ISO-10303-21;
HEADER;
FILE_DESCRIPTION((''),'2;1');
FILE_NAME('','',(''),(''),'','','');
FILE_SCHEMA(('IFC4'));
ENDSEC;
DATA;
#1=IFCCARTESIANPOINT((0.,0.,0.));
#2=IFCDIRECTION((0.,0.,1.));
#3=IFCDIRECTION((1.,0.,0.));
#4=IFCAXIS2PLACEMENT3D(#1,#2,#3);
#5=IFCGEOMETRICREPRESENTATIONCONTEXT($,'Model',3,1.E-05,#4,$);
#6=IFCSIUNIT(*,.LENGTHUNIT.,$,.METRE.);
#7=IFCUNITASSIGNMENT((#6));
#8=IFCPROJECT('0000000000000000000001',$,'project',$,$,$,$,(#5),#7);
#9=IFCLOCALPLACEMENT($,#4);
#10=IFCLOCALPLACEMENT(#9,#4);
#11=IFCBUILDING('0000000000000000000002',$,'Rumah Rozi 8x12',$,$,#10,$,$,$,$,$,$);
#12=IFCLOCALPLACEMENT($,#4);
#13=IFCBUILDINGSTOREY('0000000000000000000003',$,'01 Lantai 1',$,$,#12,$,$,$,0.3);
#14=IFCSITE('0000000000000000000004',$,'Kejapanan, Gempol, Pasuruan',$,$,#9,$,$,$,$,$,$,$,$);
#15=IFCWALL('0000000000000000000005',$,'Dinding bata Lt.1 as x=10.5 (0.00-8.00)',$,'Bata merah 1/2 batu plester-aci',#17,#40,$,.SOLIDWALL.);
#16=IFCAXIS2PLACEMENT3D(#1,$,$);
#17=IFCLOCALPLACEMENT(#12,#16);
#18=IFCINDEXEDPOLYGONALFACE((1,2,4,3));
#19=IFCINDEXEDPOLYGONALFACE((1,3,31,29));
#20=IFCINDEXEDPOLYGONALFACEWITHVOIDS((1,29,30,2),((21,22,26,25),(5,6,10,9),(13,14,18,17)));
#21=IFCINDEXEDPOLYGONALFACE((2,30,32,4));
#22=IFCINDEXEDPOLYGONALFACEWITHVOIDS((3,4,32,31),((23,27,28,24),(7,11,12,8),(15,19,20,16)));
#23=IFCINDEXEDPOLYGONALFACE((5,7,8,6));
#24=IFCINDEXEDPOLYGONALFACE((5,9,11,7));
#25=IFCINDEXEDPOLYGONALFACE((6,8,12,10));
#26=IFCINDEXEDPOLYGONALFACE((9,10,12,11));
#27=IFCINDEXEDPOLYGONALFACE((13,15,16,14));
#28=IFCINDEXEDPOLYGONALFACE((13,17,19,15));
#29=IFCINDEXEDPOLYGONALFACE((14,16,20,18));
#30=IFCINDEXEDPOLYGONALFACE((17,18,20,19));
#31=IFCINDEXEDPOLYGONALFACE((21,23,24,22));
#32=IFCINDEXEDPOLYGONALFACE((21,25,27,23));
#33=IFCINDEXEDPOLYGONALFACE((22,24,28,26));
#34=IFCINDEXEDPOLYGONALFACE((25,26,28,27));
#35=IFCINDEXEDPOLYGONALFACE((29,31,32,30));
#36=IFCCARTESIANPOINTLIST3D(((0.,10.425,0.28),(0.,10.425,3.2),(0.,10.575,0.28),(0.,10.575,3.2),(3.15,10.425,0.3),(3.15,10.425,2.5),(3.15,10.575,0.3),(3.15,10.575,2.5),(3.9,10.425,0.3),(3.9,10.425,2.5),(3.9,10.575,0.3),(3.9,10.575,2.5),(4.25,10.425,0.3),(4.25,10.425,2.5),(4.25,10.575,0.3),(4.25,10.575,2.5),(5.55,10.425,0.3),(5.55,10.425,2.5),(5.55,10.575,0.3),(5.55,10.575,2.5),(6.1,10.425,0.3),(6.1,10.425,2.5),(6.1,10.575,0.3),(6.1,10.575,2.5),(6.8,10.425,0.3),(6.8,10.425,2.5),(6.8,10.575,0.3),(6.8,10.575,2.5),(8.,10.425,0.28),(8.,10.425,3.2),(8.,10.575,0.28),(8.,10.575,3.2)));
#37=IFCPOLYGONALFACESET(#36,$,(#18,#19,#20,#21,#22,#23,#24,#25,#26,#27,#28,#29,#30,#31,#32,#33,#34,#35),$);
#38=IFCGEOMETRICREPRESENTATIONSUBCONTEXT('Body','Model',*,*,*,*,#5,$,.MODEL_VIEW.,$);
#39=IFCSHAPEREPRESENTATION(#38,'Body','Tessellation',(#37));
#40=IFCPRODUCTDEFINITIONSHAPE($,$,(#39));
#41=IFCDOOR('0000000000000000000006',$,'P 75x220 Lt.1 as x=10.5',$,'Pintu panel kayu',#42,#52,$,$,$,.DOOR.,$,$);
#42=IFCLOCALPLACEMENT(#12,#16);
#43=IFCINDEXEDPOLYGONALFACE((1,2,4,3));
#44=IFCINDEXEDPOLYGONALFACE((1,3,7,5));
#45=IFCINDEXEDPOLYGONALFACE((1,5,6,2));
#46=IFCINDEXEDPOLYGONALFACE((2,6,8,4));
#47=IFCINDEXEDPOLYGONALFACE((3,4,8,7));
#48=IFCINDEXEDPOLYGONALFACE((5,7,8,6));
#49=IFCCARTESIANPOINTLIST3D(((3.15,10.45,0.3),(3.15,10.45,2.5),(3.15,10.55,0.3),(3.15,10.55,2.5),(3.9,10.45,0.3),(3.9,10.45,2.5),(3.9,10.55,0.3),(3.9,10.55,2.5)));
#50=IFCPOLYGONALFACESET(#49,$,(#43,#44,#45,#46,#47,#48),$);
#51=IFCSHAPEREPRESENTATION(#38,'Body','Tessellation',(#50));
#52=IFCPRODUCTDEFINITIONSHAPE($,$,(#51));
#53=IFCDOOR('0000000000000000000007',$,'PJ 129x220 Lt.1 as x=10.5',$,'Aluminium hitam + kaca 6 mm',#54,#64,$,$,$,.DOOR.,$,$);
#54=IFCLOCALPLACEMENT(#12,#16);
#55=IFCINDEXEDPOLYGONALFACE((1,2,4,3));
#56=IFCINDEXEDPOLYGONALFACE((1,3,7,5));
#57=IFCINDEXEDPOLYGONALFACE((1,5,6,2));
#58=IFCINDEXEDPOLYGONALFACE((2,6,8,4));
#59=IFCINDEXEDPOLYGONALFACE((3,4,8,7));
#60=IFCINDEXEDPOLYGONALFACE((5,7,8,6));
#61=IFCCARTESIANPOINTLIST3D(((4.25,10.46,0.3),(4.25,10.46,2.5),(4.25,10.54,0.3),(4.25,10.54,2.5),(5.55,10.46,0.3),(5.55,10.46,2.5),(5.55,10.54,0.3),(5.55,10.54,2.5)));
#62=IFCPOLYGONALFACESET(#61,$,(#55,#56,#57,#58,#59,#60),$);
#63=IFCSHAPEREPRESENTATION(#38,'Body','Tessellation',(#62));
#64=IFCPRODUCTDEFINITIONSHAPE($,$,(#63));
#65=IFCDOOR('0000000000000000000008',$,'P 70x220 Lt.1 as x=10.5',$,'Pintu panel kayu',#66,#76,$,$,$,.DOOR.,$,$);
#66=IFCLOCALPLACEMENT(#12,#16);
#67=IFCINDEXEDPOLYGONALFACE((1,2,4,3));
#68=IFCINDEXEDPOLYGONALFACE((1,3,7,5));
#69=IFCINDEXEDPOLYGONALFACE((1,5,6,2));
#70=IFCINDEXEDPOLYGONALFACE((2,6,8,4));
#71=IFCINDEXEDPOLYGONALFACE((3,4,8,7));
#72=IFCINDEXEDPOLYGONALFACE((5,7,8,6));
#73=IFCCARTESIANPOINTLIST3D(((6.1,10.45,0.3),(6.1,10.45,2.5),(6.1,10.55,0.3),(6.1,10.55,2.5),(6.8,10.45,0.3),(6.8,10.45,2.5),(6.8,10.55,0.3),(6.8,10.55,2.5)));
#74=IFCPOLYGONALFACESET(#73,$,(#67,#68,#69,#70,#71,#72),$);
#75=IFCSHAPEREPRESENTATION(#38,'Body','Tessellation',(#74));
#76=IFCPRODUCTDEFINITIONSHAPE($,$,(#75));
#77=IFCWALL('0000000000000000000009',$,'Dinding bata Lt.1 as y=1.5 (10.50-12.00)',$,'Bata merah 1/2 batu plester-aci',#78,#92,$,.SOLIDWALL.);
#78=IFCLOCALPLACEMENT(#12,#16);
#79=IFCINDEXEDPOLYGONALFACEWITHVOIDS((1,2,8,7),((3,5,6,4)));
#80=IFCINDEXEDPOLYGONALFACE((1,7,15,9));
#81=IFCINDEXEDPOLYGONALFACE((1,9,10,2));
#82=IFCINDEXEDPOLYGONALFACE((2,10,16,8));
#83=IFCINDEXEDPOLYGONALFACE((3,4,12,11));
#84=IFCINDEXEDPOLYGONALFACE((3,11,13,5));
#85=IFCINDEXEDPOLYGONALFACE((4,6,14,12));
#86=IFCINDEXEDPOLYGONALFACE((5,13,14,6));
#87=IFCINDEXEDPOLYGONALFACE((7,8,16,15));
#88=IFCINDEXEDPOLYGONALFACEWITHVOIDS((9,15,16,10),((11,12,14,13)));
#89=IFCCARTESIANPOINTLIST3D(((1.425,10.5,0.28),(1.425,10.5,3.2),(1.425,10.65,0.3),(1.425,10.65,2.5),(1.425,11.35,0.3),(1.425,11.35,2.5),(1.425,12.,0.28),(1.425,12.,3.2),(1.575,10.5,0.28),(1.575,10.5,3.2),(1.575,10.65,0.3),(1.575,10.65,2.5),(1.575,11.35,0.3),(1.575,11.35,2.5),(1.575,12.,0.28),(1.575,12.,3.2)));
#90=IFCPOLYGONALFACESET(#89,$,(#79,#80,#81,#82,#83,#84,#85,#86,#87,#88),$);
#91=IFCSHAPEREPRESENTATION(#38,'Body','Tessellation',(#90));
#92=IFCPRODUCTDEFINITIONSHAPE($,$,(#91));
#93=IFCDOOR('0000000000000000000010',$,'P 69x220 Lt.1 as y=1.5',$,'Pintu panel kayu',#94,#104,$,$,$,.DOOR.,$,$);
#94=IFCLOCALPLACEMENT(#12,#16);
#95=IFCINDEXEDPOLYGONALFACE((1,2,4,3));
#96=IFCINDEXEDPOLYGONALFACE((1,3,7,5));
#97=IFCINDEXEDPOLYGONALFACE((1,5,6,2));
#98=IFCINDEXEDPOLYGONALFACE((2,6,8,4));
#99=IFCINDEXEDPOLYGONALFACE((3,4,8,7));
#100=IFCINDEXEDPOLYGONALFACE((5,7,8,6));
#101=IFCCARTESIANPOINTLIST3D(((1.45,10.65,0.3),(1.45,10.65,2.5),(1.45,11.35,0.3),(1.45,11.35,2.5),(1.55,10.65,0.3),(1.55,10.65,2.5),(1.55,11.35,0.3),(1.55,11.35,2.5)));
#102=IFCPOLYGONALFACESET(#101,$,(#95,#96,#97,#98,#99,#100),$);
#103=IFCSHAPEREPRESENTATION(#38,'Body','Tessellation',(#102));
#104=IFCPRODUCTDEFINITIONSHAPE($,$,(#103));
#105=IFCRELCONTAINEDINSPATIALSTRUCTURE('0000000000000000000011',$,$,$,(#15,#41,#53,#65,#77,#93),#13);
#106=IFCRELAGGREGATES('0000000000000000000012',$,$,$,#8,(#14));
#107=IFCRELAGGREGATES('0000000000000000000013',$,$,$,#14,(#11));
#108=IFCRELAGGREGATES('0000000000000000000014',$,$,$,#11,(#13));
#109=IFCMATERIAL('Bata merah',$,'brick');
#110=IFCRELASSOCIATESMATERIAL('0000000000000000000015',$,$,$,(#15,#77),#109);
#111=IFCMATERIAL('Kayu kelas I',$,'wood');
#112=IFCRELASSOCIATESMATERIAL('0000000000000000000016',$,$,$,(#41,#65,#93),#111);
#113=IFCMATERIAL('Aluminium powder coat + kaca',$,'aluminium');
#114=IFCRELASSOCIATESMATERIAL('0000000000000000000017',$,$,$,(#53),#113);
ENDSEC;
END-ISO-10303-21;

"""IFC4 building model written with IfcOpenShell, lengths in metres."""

from ifc_helpers import new_model, si_unit, frame, origin_with_axes, place, context, subcontext, project, spatial, line, indexed_curve, outline, extrude, material, element, fill, save


model = new_model("IFC4")

# Units and contexts
model_context = context("Model", 3, precision=1e-05, world=origin_with_axes())
body_context = subcontext(model_context, "Body", "Model", "MODEL_VIEW")
ifc_project = project(units=[si_unit("LENGTHUNIT", "METRE")], contexts=[model_context])

# Site, building, storey
site_placement = place(None, origin_with_axes())
site = spatial("IfcSite", under=ifc_project, at=site_placement, Name="Kejapanan, Gempol, Pasuruan")
building_placement = place(site_placement, origin_with_axes())
building = spatial("IfcBuilding", under=site, at=building_placement, Name="Rumah Rozi 8x12")
storey_placement = place(None, origin_with_axes())
storey = spatial("IfcBuildingStorey", under=building, at=storey_placement, Name="01 Lantai 1", Elevation=0.3)

# Shared definitions
ifc_material_1 = material(Name="Bata merah", Category="brick")
ifc_material_2 = material(Name="Aluminium powder coat + kaca", Category="aluminium")

# Shared definitions
ifc_material_3 = material(Name="Kayu kelas I", Category="wood")

# Wall, openings, doors
wall_1_placement = place(storey_placement, origin_with_axes())
wall_1 = element("IfcWall", 1, at=wall_1_placement, inside=storey, material=ifc_material_1, Name="Dinding bata Lt.1 as x=10.5 (0.00-8.00)", ObjectType="Bata merah 1/2 batu plester-aci", PredefinedType="SOLIDWALL", context=body_context, shape_type="SweptSolid", body=[
    extrude(outline(indexed_curve([(0.0, 10.425), (8.0, 10.425), (8.0, 10.575), (0.0, 10.575)], segments=[line(1, 2, 3, 4, 1)])), frame((0.0, 0.0, 0.28), z_axis=(0.0, 0.0, 1.0), x_axis=(1.0, 0.0, 0.0)), (0.0, 0.0, 1.0), 2.92),
])
opening_1_placement = place(wall_1_placement, origin_with_axes())
opening_1 = element("IfcOpeningElement", 2, at=opening_1_placement, cuts=wall_1, context=body_context, shape_type="SweptSolid", body=[
    extrude(outline(indexed_curve([(3.15, 10.415), (3.9, 10.415), (3.9, 10.585), (3.15, 10.585)], segments=[line(1, 2, 3, 4, 1)])), frame((0.0, 0.0, 0.3), z_axis=(0.0, 0.0, 1.0), x_axis=(1.0, 0.0, 0.0)), (0.0, 0.0, 1.0), 2.2),
])
opening_2_placement = place(wall_1_placement, origin_with_axes())
opening_2 = element("IfcOpeningElement", 3, at=opening_2_placement, cuts=wall_1, context=body_context, shape_type="SweptSolid", body=[
    extrude(outline(indexed_curve([(4.25, 10.415), (5.55, 10.415), (5.55, 10.585), (4.25, 10.585)], segments=[line(1, 2, 3, 4, 1)])), frame((0.0, 0.0, 0.3), z_axis=(0.0, 0.0, 1.0), x_axis=(1.0, 0.0, 0.0)), (0.0, 0.0, 1.0), 2.2),
])
opening_3_placement = place(wall_1_placement, origin_with_axes())
opening_3 = element("IfcOpeningElement", 4, at=opening_3_placement, cuts=wall_1, context=body_context, shape_type="SweptSolid", body=[
    extrude(outline(indexed_curve([(6.1, 10.415), (6.8, 10.415), (6.8, 10.585), (6.1, 10.585)], segments=[line(1, 2, 3, 4, 1)])), frame((0.0, 0.0, 0.3), z_axis=(0.0, 0.0, 1.0), x_axis=(1.0, 0.0, 0.0)), (0.0, 0.0, 1.0), 2.2),
])
door_1_placement = place(storey_placement, origin_with_axes())
door_1 = element("IfcDoor", 5, at=door_1_placement, inside=storey, material=ifc_material_3, Name="P 75x220 Lt.1 as x=10.5", ObjectType="Pintu panel kayu", PredefinedType="DOOR", context=body_context, shape_type="SweptSolid", body=[
    extrude(outline(indexed_curve([(3.15, 10.45), (3.9, 10.45), (3.9, 10.55), (3.15, 10.55)], segments=[line(1, 2, 3, 4, 1)])), frame((0.0, 0.0, 0.3), z_axis=(0.0, 0.0, 1.0), x_axis=(1.0, 0.0, 0.0)), (0.0, 0.0, 1.0), 2.2),
])
fill(opening_1, door_1)
door_2_placement = place(storey_placement, origin_with_axes())
door_2 = element("IfcDoor", 6, at=door_2_placement, inside=storey, material=ifc_material_2, Name="PJ 129x220 Lt.1 as x=10.5", ObjectType="Aluminium hitam + kaca 6 mm", PredefinedType="DOOR", context=body_context, shape_type="SweptSolid", body=[
    extrude(outline(indexed_curve([(4.25, 10.46), (5.55, 10.46), (5.55, 10.54), (4.25, 10.54)], segments=[line(1, 2, 3, 4, 1)])), frame((0.0, 0.0, 0.3), z_axis=(0.0, 0.0, 1.0), x_axis=(1.0, 0.0, 0.0)), (0.0, 0.0, 1.0), 2.2),
])
fill(opening_2, door_2)
door_3_placement = place(storey_placement, origin_with_axes())
door_3 = element("IfcDoor", 7, at=door_3_placement, inside=storey, material=ifc_material_3, Name="P 70x220 Lt.1 as x=10.5", ObjectType="Pintu panel kayu", PredefinedType="DOOR", context=body_context, shape_type="SweptSolid", body=[
    extrude(outline(indexed_curve([(6.1, 10.45), (6.8, 10.45), (6.8, 10.55), (6.1, 10.55)], segments=[line(1, 2, 3, 4, 1)])), frame((0.0, 0.0, 0.3), z_axis=(0.0, 0.0, 1.0), x_axis=(1.0, 0.0, 0.0)), (0.0, 0.0, 1.0), 2.2),
])
fill(opening_3, door_3)

# Wall, opening, door
wall_2_placement = place(storey_placement, origin_with_axes())
wall_2 = element("IfcWall", 8, at=wall_2_placement, inside=storey, material=ifc_material_1, Name="Dinding bata Lt.1 as y=1.5 (10.50-12.00)", ObjectType="Bata merah 1/2 batu plester-aci", PredefinedType="SOLIDWALL", context=body_context, shape_type="SweptSolid", body=[
    extrude(outline(indexed_curve([(1.425, 10.5), (1.575, 10.5), (1.575, 12.0), (1.425, 12.0)], segments=[line(1, 2, 3, 4, 1)])), frame((0.0, 0.0, 0.28), z_axis=(0.0, 0.0, 1.0), x_axis=(1.0, 0.0, 0.0)), (0.0, 0.0, 1.0), 2.92),
])
opening_4_placement = place(wall_2_placement, origin_with_axes())
opening_4 = element("IfcOpeningElement", 9, at=opening_4_placement, cuts=wall_2, context=body_context, shape_type="SweptSolid", body=[
    extrude(outline(indexed_curve([(1.415, 10.65), (1.585, 10.65), (1.585, 11.35), (1.415, 11.35)], segments=[line(1, 2, 3, 4, 1)])), frame((0.0, 0.0, 0.3), z_axis=(0.0, 0.0, 1.0), x_axis=(1.0, 0.0, 0.0)), (0.0, 0.0, 1.0), 2.2),
])
door_4_placement = place(storey_placement, origin_with_axes())
door_4 = element("IfcDoor", 10, at=door_4_placement, inside=storey, material=ifc_material_3, Name="P 69x220 Lt.1 as y=1.5", ObjectType="Pintu panel kayu", PredefinedType="DOOR", context=body_context, shape_type="SweptSolid", body=[
    extrude(outline(indexed_curve([(1.45, 10.65), (1.55, 10.65), (1.55, 11.35), (1.45, 11.35)], segments=[line(1, 2, 3, 4, 1)])), frame((0.0, 0.0, 0.3), z_axis=(0.0, 0.0, 1.0), x_axis=(1.0, 0.0, 0.0)), (0.0, 0.0, 1.0), 2.2),
])
fill(opening_4, door_4)

save(model, "model.ifc")
